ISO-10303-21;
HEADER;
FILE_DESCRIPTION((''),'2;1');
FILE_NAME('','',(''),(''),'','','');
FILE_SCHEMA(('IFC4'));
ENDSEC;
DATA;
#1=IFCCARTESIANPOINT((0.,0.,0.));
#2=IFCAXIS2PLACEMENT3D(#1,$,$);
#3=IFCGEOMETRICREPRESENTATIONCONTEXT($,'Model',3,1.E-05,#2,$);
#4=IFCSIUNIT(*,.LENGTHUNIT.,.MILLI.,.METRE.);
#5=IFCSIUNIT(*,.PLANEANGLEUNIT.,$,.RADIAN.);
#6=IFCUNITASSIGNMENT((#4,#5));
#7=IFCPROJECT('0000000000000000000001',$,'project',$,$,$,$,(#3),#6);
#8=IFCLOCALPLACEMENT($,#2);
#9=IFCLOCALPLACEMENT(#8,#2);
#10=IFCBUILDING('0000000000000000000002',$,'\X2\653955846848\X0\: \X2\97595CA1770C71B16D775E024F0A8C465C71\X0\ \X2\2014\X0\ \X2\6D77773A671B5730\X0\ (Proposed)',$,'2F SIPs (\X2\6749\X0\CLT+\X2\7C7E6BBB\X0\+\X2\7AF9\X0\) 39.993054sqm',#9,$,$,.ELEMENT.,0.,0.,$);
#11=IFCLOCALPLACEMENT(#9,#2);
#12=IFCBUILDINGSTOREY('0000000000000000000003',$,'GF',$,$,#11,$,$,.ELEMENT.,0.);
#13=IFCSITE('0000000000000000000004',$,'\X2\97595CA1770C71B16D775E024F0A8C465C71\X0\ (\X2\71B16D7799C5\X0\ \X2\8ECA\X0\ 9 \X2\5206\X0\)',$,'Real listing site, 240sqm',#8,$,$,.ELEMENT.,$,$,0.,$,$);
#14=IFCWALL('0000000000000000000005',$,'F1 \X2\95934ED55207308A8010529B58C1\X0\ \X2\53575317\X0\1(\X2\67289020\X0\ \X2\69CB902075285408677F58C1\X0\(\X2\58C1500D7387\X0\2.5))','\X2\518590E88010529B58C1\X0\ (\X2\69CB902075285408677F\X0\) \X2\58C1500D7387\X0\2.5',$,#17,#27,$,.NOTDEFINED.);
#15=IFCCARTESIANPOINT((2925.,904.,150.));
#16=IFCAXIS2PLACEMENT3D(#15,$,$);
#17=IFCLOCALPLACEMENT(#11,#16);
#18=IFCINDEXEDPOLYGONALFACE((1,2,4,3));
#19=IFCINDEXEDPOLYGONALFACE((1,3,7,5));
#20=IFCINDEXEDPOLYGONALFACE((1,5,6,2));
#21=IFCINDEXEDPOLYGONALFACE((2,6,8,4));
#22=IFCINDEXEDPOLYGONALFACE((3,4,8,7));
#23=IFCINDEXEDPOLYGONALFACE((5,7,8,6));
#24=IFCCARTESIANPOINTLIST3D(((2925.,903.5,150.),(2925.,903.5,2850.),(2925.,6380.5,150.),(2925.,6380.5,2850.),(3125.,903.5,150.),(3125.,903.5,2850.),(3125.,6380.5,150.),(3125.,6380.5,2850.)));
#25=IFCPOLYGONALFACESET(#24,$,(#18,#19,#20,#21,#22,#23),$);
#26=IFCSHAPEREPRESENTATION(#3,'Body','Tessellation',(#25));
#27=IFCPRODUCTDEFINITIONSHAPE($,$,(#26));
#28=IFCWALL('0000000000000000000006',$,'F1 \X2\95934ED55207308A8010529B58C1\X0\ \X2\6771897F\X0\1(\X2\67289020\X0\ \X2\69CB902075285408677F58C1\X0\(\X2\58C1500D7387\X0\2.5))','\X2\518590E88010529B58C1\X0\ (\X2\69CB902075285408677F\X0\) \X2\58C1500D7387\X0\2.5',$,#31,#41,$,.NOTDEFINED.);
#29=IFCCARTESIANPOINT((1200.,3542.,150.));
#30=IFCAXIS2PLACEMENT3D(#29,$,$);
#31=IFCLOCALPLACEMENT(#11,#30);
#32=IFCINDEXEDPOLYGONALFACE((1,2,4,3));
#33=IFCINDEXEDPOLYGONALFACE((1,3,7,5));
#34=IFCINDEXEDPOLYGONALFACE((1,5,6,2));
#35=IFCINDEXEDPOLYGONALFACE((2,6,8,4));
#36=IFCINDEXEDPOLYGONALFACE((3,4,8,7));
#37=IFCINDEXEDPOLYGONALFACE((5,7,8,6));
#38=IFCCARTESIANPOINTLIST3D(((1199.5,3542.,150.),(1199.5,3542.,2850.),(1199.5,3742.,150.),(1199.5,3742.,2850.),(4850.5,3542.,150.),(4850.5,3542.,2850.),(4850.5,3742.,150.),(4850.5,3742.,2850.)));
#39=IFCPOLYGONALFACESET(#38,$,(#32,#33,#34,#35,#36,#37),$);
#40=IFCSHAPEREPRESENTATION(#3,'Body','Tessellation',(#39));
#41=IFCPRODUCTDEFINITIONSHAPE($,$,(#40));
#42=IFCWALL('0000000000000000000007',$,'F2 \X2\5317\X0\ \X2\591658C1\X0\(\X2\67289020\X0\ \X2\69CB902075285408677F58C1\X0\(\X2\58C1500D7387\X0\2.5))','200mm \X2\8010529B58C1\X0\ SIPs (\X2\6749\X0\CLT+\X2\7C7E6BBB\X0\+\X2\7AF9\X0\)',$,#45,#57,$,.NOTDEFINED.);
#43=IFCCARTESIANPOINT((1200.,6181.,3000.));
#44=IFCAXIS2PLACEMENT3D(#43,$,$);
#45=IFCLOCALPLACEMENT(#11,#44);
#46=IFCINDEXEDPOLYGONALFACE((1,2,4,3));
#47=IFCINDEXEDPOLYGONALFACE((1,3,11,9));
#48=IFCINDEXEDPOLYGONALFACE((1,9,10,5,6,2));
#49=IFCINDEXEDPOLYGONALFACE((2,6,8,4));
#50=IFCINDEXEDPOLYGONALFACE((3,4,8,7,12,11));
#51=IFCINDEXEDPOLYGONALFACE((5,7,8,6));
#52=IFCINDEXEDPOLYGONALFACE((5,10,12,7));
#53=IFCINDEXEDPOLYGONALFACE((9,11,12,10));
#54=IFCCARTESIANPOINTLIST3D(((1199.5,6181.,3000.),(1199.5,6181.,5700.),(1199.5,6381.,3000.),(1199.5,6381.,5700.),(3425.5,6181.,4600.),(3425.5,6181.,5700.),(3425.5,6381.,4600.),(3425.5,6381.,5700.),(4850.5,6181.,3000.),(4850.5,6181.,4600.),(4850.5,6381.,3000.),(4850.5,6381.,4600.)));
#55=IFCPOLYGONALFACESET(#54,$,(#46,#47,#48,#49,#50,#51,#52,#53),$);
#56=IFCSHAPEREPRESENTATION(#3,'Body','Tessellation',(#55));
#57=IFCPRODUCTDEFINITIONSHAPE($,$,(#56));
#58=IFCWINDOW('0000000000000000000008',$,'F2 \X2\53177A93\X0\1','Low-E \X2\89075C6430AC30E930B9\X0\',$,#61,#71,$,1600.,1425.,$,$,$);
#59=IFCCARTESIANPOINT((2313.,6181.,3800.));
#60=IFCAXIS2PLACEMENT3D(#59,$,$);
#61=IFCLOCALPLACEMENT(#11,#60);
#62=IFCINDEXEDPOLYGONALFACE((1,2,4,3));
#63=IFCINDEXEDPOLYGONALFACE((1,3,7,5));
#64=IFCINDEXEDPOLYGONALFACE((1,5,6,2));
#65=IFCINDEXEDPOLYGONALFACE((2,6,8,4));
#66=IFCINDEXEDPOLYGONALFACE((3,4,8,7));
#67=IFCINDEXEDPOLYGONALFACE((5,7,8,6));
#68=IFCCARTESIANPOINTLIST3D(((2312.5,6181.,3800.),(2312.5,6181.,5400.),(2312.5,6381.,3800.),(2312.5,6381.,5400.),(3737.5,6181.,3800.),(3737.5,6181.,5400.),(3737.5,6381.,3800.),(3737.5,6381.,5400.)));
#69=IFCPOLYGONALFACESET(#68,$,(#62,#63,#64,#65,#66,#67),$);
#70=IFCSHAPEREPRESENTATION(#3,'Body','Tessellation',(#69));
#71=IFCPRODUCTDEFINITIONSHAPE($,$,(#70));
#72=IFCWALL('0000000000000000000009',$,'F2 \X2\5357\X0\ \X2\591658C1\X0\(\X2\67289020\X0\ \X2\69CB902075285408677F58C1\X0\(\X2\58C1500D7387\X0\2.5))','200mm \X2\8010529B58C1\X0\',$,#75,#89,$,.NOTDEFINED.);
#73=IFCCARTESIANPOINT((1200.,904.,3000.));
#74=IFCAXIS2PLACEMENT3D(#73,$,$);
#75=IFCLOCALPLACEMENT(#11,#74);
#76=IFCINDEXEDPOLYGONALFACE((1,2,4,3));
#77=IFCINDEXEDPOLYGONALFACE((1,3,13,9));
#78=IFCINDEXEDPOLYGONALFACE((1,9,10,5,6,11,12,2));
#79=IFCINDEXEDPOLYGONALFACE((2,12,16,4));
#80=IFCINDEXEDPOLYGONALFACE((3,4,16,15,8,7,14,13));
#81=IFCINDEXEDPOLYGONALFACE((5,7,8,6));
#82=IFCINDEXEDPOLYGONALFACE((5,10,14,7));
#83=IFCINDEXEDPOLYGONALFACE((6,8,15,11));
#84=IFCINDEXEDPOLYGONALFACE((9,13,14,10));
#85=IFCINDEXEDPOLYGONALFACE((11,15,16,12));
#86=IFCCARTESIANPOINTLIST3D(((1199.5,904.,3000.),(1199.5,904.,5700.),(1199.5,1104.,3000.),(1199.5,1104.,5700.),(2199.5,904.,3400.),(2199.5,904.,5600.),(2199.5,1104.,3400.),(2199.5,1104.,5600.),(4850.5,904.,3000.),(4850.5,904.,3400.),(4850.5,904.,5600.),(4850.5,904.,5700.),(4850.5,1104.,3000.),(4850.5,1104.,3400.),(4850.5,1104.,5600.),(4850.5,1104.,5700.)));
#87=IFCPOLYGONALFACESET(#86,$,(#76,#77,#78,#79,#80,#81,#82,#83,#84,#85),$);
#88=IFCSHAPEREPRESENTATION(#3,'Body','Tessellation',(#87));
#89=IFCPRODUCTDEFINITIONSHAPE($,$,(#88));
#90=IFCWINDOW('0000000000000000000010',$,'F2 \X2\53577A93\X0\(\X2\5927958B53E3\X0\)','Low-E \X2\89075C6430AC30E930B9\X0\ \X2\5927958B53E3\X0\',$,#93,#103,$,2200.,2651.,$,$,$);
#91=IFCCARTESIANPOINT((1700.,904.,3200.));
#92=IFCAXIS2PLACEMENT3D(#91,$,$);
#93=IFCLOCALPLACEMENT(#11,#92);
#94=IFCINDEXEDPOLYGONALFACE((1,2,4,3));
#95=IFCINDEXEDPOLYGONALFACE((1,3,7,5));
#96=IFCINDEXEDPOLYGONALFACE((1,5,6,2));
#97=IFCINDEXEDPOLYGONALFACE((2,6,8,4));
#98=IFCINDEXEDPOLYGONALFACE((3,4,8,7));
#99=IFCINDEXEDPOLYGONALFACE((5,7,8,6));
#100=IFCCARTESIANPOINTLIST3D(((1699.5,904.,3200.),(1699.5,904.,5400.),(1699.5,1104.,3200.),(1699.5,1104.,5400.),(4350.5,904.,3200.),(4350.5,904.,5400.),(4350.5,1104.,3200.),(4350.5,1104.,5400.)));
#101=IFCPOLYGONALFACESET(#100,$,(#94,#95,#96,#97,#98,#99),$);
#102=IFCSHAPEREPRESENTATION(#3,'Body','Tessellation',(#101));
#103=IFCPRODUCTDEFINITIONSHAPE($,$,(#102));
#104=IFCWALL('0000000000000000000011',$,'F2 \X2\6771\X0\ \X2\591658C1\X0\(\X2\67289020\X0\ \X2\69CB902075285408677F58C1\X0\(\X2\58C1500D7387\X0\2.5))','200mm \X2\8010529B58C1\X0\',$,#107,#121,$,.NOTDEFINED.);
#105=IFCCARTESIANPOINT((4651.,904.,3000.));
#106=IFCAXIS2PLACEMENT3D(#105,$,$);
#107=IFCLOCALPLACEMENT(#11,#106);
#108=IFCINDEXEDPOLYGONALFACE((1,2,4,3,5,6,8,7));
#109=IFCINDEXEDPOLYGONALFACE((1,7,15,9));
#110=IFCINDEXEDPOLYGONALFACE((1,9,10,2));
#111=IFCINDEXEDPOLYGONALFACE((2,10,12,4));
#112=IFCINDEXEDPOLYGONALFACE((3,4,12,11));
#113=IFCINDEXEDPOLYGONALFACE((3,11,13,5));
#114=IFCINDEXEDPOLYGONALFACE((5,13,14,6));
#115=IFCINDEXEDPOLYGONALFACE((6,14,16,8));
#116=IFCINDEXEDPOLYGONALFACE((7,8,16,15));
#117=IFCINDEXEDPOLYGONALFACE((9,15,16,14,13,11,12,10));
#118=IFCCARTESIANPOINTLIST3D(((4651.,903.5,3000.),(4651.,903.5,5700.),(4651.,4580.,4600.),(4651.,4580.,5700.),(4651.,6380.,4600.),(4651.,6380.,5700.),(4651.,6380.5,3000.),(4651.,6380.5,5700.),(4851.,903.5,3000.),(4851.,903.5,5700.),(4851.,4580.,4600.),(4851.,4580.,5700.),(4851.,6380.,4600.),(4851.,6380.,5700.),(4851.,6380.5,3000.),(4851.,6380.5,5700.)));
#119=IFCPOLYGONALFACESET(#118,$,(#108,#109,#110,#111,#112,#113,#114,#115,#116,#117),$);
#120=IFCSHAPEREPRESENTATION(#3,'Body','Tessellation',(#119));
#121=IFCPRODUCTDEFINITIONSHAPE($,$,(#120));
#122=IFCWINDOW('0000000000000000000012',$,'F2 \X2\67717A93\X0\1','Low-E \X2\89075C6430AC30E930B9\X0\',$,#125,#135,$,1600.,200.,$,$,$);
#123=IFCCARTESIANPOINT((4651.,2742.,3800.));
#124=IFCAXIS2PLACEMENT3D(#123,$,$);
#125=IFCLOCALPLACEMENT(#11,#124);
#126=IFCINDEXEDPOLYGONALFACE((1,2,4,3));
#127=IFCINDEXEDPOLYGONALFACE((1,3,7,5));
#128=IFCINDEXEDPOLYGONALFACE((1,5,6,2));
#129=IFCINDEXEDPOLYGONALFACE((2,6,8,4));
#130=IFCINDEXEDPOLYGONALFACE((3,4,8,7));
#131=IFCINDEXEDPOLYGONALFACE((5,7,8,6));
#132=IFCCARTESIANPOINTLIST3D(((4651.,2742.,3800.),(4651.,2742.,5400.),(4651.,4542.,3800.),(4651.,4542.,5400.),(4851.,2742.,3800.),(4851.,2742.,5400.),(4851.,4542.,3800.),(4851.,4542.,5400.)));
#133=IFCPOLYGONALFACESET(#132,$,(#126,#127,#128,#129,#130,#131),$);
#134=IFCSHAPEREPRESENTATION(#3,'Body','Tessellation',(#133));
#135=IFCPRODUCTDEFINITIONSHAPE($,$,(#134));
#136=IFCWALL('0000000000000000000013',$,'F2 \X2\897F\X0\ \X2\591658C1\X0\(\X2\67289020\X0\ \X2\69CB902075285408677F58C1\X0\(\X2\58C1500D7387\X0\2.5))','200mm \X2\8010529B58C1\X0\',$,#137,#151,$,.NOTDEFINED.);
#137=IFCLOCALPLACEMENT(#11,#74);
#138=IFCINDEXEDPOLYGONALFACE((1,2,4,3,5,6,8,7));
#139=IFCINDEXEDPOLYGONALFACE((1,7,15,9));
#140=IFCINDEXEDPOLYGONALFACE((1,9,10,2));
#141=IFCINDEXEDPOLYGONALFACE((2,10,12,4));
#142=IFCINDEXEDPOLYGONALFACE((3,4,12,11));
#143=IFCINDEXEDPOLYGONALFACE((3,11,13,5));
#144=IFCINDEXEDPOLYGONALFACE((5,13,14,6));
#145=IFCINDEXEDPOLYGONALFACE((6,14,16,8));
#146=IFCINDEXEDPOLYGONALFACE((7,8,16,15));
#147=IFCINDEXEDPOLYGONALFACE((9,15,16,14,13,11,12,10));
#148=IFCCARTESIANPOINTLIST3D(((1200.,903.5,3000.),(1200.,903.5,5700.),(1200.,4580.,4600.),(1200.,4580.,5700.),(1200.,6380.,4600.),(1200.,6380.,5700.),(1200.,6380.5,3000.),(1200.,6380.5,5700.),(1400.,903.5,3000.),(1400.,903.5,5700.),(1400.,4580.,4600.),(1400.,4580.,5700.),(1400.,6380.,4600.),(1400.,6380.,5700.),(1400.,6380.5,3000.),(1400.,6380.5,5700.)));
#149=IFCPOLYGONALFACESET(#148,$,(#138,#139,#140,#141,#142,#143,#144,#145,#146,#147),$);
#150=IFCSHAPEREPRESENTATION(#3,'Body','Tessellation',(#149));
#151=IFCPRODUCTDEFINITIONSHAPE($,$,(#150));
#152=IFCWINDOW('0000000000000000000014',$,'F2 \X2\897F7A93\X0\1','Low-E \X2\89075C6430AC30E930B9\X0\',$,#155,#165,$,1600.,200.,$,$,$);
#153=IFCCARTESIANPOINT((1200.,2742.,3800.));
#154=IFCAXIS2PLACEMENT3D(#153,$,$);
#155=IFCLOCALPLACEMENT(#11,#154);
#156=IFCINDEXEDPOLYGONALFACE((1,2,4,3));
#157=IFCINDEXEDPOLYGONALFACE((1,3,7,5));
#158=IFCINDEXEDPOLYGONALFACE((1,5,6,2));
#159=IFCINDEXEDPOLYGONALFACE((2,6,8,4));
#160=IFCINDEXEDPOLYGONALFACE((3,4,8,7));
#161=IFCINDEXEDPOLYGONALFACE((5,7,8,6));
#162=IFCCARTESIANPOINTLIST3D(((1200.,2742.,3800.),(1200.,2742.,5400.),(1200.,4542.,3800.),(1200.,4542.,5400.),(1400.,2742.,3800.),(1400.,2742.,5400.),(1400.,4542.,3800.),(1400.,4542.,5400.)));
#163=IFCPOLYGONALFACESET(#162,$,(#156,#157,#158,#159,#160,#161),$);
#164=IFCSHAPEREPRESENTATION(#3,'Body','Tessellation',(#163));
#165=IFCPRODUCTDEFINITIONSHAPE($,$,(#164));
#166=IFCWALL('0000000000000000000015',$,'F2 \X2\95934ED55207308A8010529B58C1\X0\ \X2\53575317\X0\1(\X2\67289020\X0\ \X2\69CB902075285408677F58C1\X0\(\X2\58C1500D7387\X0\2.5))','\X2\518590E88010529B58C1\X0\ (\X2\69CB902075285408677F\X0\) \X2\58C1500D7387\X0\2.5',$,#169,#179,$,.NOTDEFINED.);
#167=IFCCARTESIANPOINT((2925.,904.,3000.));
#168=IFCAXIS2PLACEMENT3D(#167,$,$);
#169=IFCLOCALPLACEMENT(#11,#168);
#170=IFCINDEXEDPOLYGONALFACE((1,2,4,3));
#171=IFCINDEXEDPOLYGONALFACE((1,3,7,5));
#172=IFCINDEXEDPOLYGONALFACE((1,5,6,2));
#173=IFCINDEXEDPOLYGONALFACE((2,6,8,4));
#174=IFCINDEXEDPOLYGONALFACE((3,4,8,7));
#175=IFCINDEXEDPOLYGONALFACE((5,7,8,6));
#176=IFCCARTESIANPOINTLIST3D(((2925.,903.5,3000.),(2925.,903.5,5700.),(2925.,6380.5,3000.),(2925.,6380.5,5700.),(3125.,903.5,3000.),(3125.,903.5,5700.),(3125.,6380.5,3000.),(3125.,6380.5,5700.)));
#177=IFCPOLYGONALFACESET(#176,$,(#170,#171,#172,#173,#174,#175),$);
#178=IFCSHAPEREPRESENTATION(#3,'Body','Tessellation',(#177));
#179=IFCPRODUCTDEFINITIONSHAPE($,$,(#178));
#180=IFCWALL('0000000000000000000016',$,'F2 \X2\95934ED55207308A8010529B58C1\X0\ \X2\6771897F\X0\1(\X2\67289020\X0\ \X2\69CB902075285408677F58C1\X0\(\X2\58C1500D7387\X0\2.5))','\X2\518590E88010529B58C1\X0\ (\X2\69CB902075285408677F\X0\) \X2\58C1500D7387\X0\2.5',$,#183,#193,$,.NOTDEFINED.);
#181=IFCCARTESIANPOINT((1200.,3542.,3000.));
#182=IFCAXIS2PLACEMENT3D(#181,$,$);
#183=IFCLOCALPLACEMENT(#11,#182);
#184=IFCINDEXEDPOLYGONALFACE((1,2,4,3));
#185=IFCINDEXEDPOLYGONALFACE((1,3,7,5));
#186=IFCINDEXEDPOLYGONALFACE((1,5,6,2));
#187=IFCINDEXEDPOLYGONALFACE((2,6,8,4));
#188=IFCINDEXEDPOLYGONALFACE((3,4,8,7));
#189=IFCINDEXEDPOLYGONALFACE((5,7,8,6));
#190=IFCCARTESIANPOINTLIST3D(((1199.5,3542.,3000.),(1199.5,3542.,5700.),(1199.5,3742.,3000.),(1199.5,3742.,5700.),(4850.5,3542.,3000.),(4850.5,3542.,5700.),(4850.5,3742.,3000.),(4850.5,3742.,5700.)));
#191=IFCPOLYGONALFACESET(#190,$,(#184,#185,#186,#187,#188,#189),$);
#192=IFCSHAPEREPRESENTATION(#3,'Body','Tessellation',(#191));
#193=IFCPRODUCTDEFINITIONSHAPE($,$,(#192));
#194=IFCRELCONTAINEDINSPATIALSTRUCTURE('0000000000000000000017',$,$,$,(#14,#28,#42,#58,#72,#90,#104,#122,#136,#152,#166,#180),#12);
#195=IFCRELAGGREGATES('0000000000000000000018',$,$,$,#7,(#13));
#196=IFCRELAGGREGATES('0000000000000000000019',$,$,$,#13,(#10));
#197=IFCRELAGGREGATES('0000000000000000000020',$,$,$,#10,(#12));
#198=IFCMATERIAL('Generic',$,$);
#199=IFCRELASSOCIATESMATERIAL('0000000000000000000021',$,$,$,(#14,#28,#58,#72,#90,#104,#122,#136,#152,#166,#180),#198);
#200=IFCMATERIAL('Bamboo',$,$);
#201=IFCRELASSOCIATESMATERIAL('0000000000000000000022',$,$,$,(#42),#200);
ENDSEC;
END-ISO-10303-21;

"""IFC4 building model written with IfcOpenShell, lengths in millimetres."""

from ifc_helpers import new_model, si_unit, frame, frame_2d, origin, place, context, project, spatial, rectangle, extrude, material, element, fill, save


model = new_model("IFC4")

# Units and contexts
model_context = context("Model", 3, precision=1e-05, world=origin())
ifc_project = project(units=[si_unit("LENGTHUNIT", "METRE", prefix="MILLI"), si_unit("PLANEANGLEUNIT", "RADIAN")], contexts=[model_context])

# Site, building, storey
site_placement = place(None, origin())
site = spatial("IfcSite", under=ifc_project, at=site_placement, Name="静岡県熱海市伊豆山 (熱海駅 車 9 分)", ObjectType="Real listing site, 240sqm", CompositionType="ELEMENT", RefElevation=0.0)
building_placement = place(site_placement, origin())
building = spatial("IfcBuilding", under=site, at=building_placement, Name="改善案: 静岡県熱海市伊豆山 — 海眺望地 (Proposed)", ObjectType="2F SIPs (杉CLT+籾殻+竹) 39.993054sqm", CompositionType="ELEMENT", ElevationOfRefHeight=0.0, ElevationOfTerrain=0.0)
storey_placement = place(building_placement, origin())
storey = spatial("IfcBuildingStorey", under=building, at=storey_placement, Name="GF", CompositionType="ELEMENT", Elevation=0.0)

# Shared definitions
ifc_material_1 = material(Name="Generic")

# Shared definitions
ifc_material_2 = material(Name="Bamboo")

# Walls
wall_1_placement = place(storey_placement, frame((2925.0, 904.0, 150.0)))
element("IfcWall", 1, at=wall_1_placement, inside=storey, material=ifc_material_1, Name="F1 間仕切り耐力壁 南北1(木造 構造用合板壁(壁倍率2.5))", Description="内部耐力壁 (構造用合板) 壁倍率2.5", PredefinedType="NOTDEFINED", context=model_context, shape_type="SweptSolid", body=[
    extrude(rectangle(XDim=200.0, YDim=5477.0, at=frame_2d((100.0, 2738.0))), frame((2925.0, 904.0, 150.0)), (0.0, 0.0, 1.0), 2700.0),
])
wall_2_placement = place(storey_placement, frame((1200.0, 3542.0, 150.0)))
element("IfcWall", 2, at=wall_2_placement, inside=storey, material=ifc_material_1, Name="F1 間仕切り耐力壁 東西1(木造 構造用合板壁(壁倍率2.5))", Description="内部耐力壁 (構造用合板) 壁倍率2.5", PredefinedType="NOTDEFINED", context=model_context, shape_type="SweptSolid", body=[
    extrude(rectangle(XDim=3651.0, YDim=200.0, at=frame_2d((1825.0, 100.0))), frame((1200.0, 3542.0, 150.0)), (0.0, 0.0, 1.0), 2700.0),
])

# Walls, openings, windows
wall_3_placement = place(storey_placement, frame((1200.0, 6181.0, 3000.0)))
wall_3 = element("IfcWall", 3, at=wall_3_placement, inside=storey, material=ifc_material_2, Name="F2 北 外壁(木造 構造用合板壁(壁倍率2.5))", Description="200mm 耐力壁 SIPs (杉CLT+籾殻+竹)", PredefinedType="NOTDEFINED", context=model_context, shape_type="SweptSolid", body=[
    extrude(rectangle(XDim=3651.0, YDim=200.0, at=frame_2d((1825.0, 100.0))), frame((1200.0, 6181.0, 3000.0)), (0.0, 0.0, 1.0), 2700.0),
])
opening_1_placement = place(storey_placement, frame((2313.0, 6181.0, 3800.0)))
opening_1 = element("IfcOpeningElement", 4, at=opening_1_placement, cuts=wall_3, PredefinedType="NOTDEFINED", context=model_context, shape_type="SweptSolid", body=[
    extrude(rectangle(XDim=1425.0, YDim=200.0, at=frame_2d((712.0, 100.0))), frame((2313.0, 6181.0, 3800.0)), (0.0, 0.0, 1.0), 1600.0),
])
window_1_placement = place(storey_placement, frame((2313.0, 6181.0, 3800.0)))
window_1 = element("IfcWindow", 5, at=window_1_placement, inside=storey, material=ifc_material_1, Name="F2 北窓1", Description="Low-E 複層ガラス", OverallHeight=1600.0, OverallWidth=1425.0, context=model_context, shape_type="SweptSolid", body=[
    extrude(rectangle(XDim=1425.0, YDim=200.0, at=frame_2d((712.0, 100.0))), frame((2313.0, 6181.0, 3800.0)), (0.0, 0.0, 1.0), 1600.0),
])
fill(opening_1, window_1)
wall_4_placement = place(storey_placement, frame((1200.0, 904.0, 3000.0)))
wall_4 = element("IfcWall", 6, at=wall_4_placement, inside=storey, material=ifc_material_1, Name="F2 南 外壁(木造 構造用合板壁(壁倍率2.5))", Description="200mm 耐力壁", PredefinedType="NOTDEFINED", context=model_context, shape_type="SweptSolid", body=[
    extrude(rectangle(XDim=3651.0, YDim=200.0, at=frame_2d((1825.0, 100.0))), frame((1200.0, 904.0, 3000.0)), (0.0, 0.0, 1.0), 2700.0),
])
opening_2_placement = place(storey_placement, frame((1700.0, 904.0, 3200.0)))
opening_2 = element("IfcOpeningElement", 7, at=opening_2_placement, cuts=wall_4, PredefinedType="NOTDEFINED", context=model_context, shape_type="SweptSolid", body=[
    extrude(rectangle(XDim=2651.0, YDim=200.0, at=frame_2d((1325.0, 100.0))), frame((1700.0, 904.0, 3200.0)), (0.0, 0.0, 1.0), 2200.0),
])
window_2_placement = place(storey_placement, frame((1700.0, 904.0, 3200.0)))
window_2 = element("IfcWindow", 8, at=window_2_placement, inside=storey, material=ifc_material_1, Name="F2 南窓(大開口)", Description="Low-E 複層ガラス 大開口", OverallHeight=2200.0, OverallWidth=2651.0, context=model_context, shape_type="SweptSolid", body=[
    extrude(rectangle(XDim=2651.0, YDim=200.0, at=frame_2d((1325.0, 100.0))), frame((1700.0, 904.0, 3200.0)), (0.0, 0.0, 1.0), 2200.0),
])
fill(opening_2, window_2)
wall_5_placement = place(storey_placement, frame((4651.0, 904.0, 3000.0)))
wall_5 = element("IfcWall", 9, at=wall_5_placement, inside=storey, material=ifc_material_1, Name="F2 東 外壁(木造 構造用合板壁(壁倍率2.5))", Description="200mm 耐力壁", PredefinedType="NOTDEFINED", context=model_context, shape_type="SweptSolid", body=[
    extrude(rectangle(XDim=200.0, YDim=5477.0, at=frame_2d((100.0, 2738.0))), frame((4651.0, 904.0, 3000.0)), (0.0, 0.0, 1.0), 2700.0),
])
opening_3_placement = place(storey_placement, frame((4651.0, 2742.0, 3800.0)))
opening_3 = element("IfcOpeningElement", 10, at=opening_3_placement, cuts=wall_5, PredefinedType="NOTDEFINED", context=model_context, shape_type="SweptSolid", body=[
    extrude(rectangle(XDim=200.0, YDim=1800.0, at=frame_2d((100.0, 900.0))), frame((4651.0, 2742.0, 3800.0)), (0.0, 0.0, 1.0), 1600.0),
])
window_3_placement = place(storey_placement, frame((4651.0, 2742.0, 3800.0)))
window_3 = element("IfcWindow", 11, at=window_3_placement, inside=storey, material=ifc_material_1, Name="F2 東窓1", Description="Low-E 複層ガラス", OverallHeight=1600.0, OverallWidth=200.0, context=model_context, shape_type="SweptSolid", body=[
    extrude(rectangle(XDim=200.0, YDim=1800.0, at=frame_2d((100.0, 900.0))), frame((4651.0, 2742.0, 3800.0)), (0.0, 0.0, 1.0), 1600.0),
])
fill(opening_3, window_3)
wall_6_placement = place(storey_placement, frame((1200.0, 904.0, 3000.0)))
wall_6 = element("IfcWall", 12, at=wall_6_placement, inside=storey, material=ifc_material_1, Name="F2 西 外壁(木造 構造用合板壁(壁倍率2.5))", Description="200mm 耐力壁", PredefinedType="NOTDEFINED", context=model_context, shape_type="SweptSolid", body=[
    extrude(rectangle(XDim=200.0, YDim=5477.0, at=frame_2d((100.0, 2738.0))), frame((1200.0, 904.0, 3000.0)), (0.0, 0.0, 1.0), 2700.0),
])
opening_4_placement = place(storey_placement, frame((1200.0, 2742.0, 3800.0)))
opening_4 = element("IfcOpeningElement", 13, at=opening_4_placement, cuts=wall_6, PredefinedType="NOTDEFINED", context=model_context, shape_type="SweptSolid", body=[
    extrude(rectangle(XDim=200.0, YDim=1800.0, at=frame_2d((100.0, 900.0))), frame((1200.0, 2742.0, 3800.0)), (0.0, 0.0, 1.0), 1600.0),
])
window_4_placement = place(storey_placement, frame((1200.0, 2742.0, 3800.0)))
window_4 = element("IfcWindow", 14, at=window_4_placement, inside=storey, material=ifc_material_1, Name="F2 西窓1", Description="Low-E 複層ガラス", OverallHeight=1600.0, OverallWidth=200.0, context=model_context, shape_type="SweptSolid", body=[
    extrude(rectangle(XDim=200.0, YDim=1800.0, at=frame_2d((100.0, 900.0))), frame((1200.0, 2742.0, 3800.0)), (0.0, 0.0, 1.0), 1600.0),
])
fill(opening_4, window_4)

# Walls
wall_7_placement = place(storey_placement, frame((2925.0, 904.0, 3000.0)))
element("IfcWall", 15, at=wall_7_placement, inside=storey, material=ifc_material_1, Name="F2 間仕切り耐力壁 南北1(木造 構造用合板壁(壁倍率2.5))", Description="内部耐力壁 (構造用合板) 壁倍率2.5", PredefinedType="NOTDEFINED", context=model_context, shape_type="SweptSolid", body=[
    extrude(rectangle(XDim=200.0, YDim=5477.0, at=frame_2d((100.0, 2738.0))), frame((2925.0, 904.0, 3000.0)), (0.0, 0.0, 1.0), 2700.0),
])
wall_8_placement = place(storey_placement, frame((1200.0, 3542.0, 3000.0)))
element("IfcWall", 16, at=wall_8_placement, inside=storey, material=ifc_material_1, Name="F2 間仕切り耐力壁 東西1(木造 構造用合板壁(壁倍率2.5))", Description="内部耐力壁 (構造用合板) 壁倍率2.5", PredefinedType="NOTDEFINED", context=model_context, shape_type="SweptSolid", body=[
    extrude(rectangle(XDim=3651.0, YDim=200.0, at=frame_2d((1825.0, 100.0))), frame((1200.0, 3542.0, 3000.0)), (0.0, 0.0, 1.0), 2700.0),
])

save(model, "model.ifc")
